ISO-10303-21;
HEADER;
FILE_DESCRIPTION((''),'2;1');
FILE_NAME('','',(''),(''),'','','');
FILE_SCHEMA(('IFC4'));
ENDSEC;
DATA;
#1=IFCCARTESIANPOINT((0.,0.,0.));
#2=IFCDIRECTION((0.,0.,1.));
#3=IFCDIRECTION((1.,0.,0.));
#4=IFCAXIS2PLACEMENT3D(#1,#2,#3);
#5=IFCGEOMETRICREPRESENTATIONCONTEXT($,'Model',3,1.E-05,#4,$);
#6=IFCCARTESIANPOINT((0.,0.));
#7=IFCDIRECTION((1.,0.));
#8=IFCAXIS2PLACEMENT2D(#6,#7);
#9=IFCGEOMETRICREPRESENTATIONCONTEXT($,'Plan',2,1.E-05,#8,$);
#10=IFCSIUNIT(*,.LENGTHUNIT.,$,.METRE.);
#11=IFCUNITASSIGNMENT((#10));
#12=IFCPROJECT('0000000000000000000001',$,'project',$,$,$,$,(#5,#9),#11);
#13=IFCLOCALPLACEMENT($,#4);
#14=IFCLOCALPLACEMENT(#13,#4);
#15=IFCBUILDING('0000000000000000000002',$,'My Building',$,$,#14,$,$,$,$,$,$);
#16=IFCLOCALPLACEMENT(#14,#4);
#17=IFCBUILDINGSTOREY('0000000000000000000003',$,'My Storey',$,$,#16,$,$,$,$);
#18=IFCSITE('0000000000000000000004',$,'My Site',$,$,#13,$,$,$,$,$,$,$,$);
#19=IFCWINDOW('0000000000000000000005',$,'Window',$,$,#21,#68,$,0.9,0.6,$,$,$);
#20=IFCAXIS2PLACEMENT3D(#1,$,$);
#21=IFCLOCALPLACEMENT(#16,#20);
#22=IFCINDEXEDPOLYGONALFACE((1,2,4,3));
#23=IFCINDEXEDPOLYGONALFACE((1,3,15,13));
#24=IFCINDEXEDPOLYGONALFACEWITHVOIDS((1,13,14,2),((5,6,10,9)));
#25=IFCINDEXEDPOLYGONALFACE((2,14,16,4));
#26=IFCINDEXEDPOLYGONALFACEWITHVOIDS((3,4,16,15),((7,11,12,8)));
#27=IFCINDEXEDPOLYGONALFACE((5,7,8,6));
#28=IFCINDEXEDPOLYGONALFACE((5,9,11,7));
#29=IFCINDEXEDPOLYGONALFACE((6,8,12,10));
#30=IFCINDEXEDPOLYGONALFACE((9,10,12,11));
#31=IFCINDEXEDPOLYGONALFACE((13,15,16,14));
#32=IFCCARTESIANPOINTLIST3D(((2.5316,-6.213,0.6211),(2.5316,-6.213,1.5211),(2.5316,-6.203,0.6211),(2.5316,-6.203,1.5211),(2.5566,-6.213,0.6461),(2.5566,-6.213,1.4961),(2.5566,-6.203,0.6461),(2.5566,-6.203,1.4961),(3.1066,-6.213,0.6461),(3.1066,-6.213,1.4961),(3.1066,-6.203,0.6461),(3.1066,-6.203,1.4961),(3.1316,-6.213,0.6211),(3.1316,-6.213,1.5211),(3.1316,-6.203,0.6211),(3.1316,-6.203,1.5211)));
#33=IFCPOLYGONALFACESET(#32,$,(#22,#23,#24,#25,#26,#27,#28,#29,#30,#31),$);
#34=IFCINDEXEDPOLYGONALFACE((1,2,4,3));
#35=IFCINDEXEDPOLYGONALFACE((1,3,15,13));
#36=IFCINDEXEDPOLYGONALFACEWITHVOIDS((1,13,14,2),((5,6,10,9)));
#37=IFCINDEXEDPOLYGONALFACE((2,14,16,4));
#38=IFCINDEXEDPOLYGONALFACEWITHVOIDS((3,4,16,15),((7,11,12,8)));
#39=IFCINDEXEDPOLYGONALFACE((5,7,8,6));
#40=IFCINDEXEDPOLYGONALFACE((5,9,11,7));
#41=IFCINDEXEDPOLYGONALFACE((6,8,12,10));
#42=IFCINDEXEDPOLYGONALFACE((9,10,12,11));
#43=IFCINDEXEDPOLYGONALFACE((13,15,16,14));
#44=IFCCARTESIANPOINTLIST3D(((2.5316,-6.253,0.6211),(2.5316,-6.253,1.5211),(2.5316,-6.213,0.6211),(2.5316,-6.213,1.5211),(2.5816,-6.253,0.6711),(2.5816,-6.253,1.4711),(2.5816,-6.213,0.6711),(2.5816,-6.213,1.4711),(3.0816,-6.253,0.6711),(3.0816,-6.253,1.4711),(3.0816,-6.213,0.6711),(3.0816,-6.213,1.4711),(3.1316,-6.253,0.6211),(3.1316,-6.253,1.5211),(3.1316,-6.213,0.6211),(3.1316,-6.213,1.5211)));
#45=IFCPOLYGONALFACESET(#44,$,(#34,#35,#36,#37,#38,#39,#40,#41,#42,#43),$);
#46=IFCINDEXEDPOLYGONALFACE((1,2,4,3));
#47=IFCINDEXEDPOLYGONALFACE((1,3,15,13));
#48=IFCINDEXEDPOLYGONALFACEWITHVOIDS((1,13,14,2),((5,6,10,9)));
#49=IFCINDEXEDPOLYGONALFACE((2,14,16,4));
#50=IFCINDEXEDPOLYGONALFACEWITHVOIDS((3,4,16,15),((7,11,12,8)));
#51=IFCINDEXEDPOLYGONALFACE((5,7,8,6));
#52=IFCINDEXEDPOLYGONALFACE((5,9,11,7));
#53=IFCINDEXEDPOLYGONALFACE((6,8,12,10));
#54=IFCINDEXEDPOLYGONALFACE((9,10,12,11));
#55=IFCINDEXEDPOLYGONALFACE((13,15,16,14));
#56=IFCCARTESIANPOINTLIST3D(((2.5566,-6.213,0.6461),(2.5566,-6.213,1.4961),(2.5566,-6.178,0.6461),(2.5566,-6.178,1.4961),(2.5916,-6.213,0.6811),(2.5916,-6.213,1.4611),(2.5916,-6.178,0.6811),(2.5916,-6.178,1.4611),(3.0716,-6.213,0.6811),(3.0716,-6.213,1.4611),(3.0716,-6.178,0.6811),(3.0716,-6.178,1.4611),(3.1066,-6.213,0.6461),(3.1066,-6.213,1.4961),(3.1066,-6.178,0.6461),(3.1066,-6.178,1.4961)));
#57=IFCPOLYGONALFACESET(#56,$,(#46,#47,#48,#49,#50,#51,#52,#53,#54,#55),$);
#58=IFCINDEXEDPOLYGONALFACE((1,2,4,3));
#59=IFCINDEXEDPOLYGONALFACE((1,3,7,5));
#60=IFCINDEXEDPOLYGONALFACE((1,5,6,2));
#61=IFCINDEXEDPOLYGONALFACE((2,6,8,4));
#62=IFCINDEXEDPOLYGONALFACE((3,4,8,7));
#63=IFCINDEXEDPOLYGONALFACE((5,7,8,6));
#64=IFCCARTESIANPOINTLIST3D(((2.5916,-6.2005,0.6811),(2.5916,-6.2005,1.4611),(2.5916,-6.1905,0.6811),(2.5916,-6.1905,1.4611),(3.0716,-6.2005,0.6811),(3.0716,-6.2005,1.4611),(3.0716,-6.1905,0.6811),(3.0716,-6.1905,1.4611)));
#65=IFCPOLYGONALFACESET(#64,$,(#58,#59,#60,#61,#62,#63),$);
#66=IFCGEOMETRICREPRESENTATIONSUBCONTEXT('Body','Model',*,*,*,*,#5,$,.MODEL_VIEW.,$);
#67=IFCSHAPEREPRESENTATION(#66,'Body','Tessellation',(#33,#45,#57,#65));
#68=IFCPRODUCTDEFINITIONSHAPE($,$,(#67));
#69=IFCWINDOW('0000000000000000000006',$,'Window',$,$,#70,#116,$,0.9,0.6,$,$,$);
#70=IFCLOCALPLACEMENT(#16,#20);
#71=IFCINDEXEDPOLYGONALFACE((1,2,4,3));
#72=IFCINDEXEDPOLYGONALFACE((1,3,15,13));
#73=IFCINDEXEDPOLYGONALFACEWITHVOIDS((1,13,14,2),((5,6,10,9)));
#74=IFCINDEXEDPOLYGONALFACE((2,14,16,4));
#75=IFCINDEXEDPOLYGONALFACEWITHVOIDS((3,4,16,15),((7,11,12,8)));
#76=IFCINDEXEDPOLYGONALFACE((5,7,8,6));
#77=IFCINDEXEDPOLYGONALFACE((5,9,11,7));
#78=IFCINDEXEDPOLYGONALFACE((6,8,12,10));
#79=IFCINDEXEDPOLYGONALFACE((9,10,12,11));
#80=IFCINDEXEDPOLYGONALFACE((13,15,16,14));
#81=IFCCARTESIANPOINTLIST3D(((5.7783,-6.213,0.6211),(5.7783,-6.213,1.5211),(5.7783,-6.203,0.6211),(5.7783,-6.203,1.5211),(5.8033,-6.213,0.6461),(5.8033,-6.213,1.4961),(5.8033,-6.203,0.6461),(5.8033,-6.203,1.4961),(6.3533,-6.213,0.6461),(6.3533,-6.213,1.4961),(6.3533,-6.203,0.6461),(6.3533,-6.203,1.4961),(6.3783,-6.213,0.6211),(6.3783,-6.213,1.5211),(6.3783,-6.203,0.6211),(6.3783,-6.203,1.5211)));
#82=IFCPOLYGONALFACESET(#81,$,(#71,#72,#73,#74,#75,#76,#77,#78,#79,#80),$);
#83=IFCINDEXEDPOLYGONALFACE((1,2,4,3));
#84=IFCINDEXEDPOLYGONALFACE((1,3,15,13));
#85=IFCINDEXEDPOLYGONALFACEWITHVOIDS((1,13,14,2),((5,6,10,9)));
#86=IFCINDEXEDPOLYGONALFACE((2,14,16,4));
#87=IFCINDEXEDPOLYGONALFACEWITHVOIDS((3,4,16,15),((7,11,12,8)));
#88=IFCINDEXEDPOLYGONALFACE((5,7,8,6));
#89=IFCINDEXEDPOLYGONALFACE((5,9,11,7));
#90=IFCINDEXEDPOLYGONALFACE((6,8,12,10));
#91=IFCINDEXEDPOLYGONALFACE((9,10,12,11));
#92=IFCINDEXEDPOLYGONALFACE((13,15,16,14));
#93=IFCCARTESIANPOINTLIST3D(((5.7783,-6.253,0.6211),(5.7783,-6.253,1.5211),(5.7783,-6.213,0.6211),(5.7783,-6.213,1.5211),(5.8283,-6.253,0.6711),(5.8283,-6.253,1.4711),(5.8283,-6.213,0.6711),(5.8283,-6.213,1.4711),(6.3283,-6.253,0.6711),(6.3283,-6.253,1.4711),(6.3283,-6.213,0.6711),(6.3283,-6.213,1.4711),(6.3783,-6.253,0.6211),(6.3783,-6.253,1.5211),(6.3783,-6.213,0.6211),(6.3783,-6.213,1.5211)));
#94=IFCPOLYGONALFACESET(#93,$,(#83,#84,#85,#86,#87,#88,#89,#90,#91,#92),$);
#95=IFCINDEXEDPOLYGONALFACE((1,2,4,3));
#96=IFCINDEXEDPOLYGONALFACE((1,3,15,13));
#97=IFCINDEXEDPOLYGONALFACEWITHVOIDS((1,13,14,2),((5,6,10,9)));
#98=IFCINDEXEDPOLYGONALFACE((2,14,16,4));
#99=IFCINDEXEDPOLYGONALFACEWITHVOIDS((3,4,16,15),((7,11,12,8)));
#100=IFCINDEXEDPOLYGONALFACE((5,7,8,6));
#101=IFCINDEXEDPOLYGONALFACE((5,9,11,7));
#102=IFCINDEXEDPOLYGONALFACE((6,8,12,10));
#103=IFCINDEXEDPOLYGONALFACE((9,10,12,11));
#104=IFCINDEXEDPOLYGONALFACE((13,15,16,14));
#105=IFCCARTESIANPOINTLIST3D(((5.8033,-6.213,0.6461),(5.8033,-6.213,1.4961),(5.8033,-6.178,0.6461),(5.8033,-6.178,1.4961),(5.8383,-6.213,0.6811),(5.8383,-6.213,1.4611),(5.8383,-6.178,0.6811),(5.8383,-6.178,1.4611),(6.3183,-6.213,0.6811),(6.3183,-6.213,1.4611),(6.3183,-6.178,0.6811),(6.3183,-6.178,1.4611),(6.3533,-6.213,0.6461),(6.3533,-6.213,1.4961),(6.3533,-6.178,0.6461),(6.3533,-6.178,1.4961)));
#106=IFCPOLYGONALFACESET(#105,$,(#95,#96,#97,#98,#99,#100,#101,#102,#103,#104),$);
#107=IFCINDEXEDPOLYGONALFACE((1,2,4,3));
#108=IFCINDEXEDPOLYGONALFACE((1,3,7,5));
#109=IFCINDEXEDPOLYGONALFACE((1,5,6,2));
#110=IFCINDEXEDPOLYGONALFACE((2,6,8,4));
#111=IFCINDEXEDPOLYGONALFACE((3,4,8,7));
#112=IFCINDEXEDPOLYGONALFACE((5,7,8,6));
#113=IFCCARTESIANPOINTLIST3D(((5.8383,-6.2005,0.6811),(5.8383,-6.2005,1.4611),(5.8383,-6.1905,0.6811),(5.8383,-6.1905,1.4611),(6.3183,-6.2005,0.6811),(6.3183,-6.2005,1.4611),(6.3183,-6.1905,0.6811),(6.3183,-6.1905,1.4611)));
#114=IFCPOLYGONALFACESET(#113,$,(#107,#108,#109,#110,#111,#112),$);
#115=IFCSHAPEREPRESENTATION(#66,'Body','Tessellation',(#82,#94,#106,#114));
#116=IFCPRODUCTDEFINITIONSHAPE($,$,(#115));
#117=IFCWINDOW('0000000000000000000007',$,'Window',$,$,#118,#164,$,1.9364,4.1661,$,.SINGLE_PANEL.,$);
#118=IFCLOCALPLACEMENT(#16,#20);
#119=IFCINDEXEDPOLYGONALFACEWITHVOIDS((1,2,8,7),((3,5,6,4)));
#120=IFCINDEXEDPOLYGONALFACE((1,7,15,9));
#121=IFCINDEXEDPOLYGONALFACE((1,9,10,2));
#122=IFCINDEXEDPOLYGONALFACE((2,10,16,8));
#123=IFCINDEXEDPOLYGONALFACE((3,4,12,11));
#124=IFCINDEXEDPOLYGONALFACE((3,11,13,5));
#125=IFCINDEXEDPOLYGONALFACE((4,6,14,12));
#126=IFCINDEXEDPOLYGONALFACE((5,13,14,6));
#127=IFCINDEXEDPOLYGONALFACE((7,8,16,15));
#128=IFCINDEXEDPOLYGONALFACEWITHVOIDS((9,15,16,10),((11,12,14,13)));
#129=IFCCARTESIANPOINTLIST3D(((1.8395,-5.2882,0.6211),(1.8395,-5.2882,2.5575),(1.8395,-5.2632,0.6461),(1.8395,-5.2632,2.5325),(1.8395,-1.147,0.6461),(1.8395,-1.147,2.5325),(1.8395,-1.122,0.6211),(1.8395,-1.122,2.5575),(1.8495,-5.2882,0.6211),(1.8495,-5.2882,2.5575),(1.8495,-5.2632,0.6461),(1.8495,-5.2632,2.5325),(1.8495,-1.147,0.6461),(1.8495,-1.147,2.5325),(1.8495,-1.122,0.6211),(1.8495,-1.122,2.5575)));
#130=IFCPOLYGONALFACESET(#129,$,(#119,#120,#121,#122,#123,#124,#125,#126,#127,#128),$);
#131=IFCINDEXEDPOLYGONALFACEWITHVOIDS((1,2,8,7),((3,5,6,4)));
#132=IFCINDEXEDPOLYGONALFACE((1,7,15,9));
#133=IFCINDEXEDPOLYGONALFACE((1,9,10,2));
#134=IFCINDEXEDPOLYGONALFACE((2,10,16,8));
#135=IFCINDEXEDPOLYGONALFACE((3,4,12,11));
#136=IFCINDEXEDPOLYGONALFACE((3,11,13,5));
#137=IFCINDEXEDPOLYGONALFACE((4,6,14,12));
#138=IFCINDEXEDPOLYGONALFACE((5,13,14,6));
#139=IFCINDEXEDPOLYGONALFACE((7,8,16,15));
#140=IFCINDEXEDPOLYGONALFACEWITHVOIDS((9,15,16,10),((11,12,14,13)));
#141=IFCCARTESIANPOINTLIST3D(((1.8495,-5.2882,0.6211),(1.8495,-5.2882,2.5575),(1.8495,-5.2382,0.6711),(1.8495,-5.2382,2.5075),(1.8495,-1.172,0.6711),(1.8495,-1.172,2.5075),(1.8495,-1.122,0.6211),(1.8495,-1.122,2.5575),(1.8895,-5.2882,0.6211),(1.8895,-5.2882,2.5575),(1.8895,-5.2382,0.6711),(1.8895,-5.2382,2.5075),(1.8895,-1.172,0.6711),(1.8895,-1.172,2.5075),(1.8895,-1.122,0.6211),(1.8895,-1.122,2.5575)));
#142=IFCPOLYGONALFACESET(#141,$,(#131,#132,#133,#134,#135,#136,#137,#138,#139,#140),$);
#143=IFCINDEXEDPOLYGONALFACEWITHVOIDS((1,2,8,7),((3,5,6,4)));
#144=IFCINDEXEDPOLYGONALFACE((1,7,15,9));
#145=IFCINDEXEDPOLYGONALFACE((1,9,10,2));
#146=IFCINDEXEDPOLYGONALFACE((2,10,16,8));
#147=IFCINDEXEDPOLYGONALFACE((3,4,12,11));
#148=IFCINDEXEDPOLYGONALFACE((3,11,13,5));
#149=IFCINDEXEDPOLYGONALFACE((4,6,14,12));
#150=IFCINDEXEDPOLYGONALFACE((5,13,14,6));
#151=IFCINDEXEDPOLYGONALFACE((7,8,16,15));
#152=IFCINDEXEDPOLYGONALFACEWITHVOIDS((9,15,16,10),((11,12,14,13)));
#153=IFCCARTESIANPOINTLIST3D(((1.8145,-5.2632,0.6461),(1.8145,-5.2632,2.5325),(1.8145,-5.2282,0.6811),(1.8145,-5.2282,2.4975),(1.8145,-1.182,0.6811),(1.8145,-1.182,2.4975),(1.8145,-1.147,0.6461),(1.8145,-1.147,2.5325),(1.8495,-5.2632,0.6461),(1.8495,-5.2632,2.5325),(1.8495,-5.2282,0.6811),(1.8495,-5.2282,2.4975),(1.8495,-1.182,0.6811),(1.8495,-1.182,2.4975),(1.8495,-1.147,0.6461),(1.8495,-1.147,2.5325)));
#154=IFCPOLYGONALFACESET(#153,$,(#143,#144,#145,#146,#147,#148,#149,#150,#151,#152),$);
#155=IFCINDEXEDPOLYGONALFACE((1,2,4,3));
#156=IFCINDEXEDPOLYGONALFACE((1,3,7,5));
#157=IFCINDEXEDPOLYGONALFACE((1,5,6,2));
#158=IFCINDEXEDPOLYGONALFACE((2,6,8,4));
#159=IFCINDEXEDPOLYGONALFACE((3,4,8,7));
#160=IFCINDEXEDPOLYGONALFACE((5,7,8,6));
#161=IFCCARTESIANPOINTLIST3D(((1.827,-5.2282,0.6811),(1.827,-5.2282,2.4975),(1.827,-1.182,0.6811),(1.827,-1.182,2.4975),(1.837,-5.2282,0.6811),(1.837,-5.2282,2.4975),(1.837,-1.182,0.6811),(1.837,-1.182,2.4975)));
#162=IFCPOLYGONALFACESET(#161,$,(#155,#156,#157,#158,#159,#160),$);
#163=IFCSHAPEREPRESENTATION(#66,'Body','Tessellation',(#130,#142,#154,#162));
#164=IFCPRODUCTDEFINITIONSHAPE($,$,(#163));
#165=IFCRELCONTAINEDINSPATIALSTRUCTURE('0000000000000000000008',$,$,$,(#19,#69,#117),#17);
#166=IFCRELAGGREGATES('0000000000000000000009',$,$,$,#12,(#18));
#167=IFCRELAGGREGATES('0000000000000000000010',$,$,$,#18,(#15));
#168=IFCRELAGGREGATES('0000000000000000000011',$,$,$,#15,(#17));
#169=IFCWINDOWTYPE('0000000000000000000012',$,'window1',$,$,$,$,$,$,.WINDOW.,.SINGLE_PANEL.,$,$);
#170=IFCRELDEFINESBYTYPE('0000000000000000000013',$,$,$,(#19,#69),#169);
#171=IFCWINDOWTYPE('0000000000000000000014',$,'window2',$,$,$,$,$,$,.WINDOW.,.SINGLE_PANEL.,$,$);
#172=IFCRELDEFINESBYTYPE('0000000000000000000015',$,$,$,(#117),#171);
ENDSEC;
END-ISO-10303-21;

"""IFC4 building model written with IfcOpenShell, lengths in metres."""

from ifc_helpers import new_model, entity, si_unit, frame, origin_with_axes, origin_2d_with_axis, place, context, subcontext, project, spatial, line, indexed_curve, outline, extrude, shape, source, transform, mapped, type_object, type_shapes, element, save


model = new_model("IFC4")

# Units and contexts
model_context = context("Model", 3, precision=1e-05, world=origin_with_axes())
plan_context = context("Plan", 2, precision=1e-05, world=origin_2d_with_axis())
body_context_1 = subcontext(model_context, "Body", "Model", "MODEL_VIEW")
body_context_2 = subcontext(plan_context, "Body", "Plan", "PLAN_VIEW")
ifc_project = project(units=[si_unit("LENGTHUNIT", "METRE")], contexts=[model_context, plan_context])

# Site, building, storey
site_placement = place(None, origin_with_axes())
site = spatial("IfcSite", under=ifc_project, at=site_placement, Name="My Site")
building_placement = place(site_placement, origin_with_axes())
building = spatial("IfcBuilding", under=site, at=building_placement, Name="My Building")
storey_placement = place(building_placement, origin_with_axes())
storey = spatial("IfcBuildingStorey", under=building, at=storey_placement, Name="My Storey")

# Windows
window_type_1 = type_object("IfcWindowType", Name="window1", PartitioningType="SINGLE_PANEL", PredefinedType="WINDOW")
shared_shape_1 = source(origin_with_axes(), body_context_1, "Body", "SweptSolid", [
    extrude(outline(indexed_curve([(0.0, 0.0), (0.6, 0.0), (0.6, 0.9), (0.0, 0.9)], segments=[line(1, 2, 3, 4, 1)]), holes=[indexed_curve([(0.025, 0.025), (0.575, 0.025), (0.575, 0.875), (0.025, 0.875)], segments=[line(1, 2, 3, 4, 1)])]), frame((0.0, 0.09, 0.0), z_axis=(0.0, -1.0, 0.0), x_axis=(1.0, 0.0, 0.0)), (0.0, 0.0, -1.0), 0.01),
    extrude(outline(indexed_curve([(0.0, 0.0), (0.6, 0.0), (0.6, 0.9), (0.0, 0.9)], segments=[line(1, 2, 3, 4, 1)]), holes=[indexed_curve([(0.05, 0.05), (0.55, 0.05), (0.55, 0.85), (0.05, 0.85)], segments=[line(1, 2, 3, 4, 1)])]), frame((0.0, 0.05, 0.0), z_axis=(0.0, -1.0, 0.0), x_axis=(1.0, 0.0, 0.0)), (0.0, 0.0, -1.0), 0.04),
    extrude(outline(indexed_curve([(0.0, 0.0), (0.55, 0.0), (0.55, 0.85), (0.0, 0.85)], segments=[line(1, 2, 3, 4, 1)]), holes=[indexed_curve([(0.035, 0.035), (0.515, 0.035), (0.515, 0.815), (0.035, 0.815)], segments=[line(1, 2, 3, 4, 1)])]), frame((0.025, 0.09, 0.025), z_axis=(0.0, -1.0, 0.0), x_axis=(1.0, 0.0, 0.0)), (0.0, 0.0, -1.0), 0.035),
    extrude(outline(indexed_curve([(0.035, 0.035), (0.515, 0.035), (0.515, 0.815), (0.035, 0.815)], segments=[line(1, 2, 3, 4, 1)])), frame((0.025, 0.1025, 0.025), z_axis=(0.0, -1.0, 0.0), x_axis=(1.0, 0.0, 0.0)), (0.0, 0.0, -1.0), 0.01),
])
shared_shape_2 = source(origin_with_axes(), body_context_2, "Body", "Curve2D", [
    entity("IfcIndexedPolyCurve", entity("IfcCartesianPointList2D", [[0.05, 0.05], [0.55, 0.05]])),
    entity("IfcIndexedPolyCurve", entity("IfcCartesianPointList2D", [[0.0, 0.1], [0.025, 0.1], [0.025, 0.09], [0.05, 0.09], [0.05, 0.05], [0.0, 0.05]]), [entity("IfcLineIndex", [1, 2, 3, 4, 5, 6, 1])]),
    entity("IfcIndexedPolyCurve", entity("IfcCartesianPointList2D", [[0.6, 0.1], [0.575, 0.1], [0.575, 0.09], [0.55, 0.09], [0.55, 0.05], [0.6, 0.05]]), [entity("IfcLineIndex", [1, 2, 3, 4, 5, 6, 1])]),
    entity("IfcIndexedPolyCurve", entity("IfcCartesianPointList2D", [[0.025, 0.09], [0.06, 0.09], [0.06, 0.125], [0.025, 0.125]]), [entity("IfcLineIndex", [1, 2, 3, 4, 1])]),
    entity("IfcIndexedPolyCurve", entity("IfcCartesianPointList2D", [[0.575, 0.09], [0.54, 0.09], [0.54, 0.125], [0.575, 0.125]]), [entity("IfcLineIndex", [1, 2, 3, 4, 1])]),
    entity("IfcIndexedPolyCurve", entity("IfcCartesianPointList2D", [[0.06, 0.09], [0.54, 0.09]])),
    entity("IfcIndexedPolyCurve", entity("IfcCartesianPointList2D", [[0.06, 0.125], [0.54, 0.125]])),
    entity("IfcIndexedPolyCurve", entity("IfcCartesianPointList2D", [[0.06, 0.1075], [0.54, 0.1075]])),
])
type_shapes(window_type_1, [shared_shape_1, shared_shape_2])
for number, where, z_axis, x_axis, name in (
    (1, (2.5316, -6.303, 0.6211), (0.0, 0.0, 1.0), (1.0, 0.0, 0.0), "Window"),
    (2, (5.7783, -6.303, 0.6211), (0.0, 0.0, 1.0), (1.0, 0.0, 0.0), "Window"),
):
    element("IfcWindow", number, at=place(storey_placement, frame(where, z_axis=z_axis, x_axis=x_axis)), inside=storey, type_object=window_type_1, Name=name, OverallHeight=0.9, OverallWidth=0.6, shapes=[
        shape(body_context_1, "Body", "MappedRepresentation", [mapped(shared_shape_1, transform((0.0, 0.0, 0.0), x_axis=(1.0, 0.0, 0.0), y_axis=(0.0, 1.0, 0.0), z_axis=(0.0, 0.0, 1.0), scale=1.0))]),
        shape(body_context_2, "Body", "MappedRepresentation", [mapped(shared_shape_2, transform((0.0, 0.0, 0.0), x_axis=(1.0, 0.0, 0.0), y_axis=(0.0, 1.0, 0.0), z_axis=(0.0, 0.0, 1.0), scale=1.0))]),
    ])
window_type_2 = type_object("IfcWindowType", Name="window2", PartitioningType="SINGLE_PANEL", PredefinedType="WINDOW")
shared_shape_3 = source(origin_with_axes(), body_context_1, "Body", "SweptSolid", [
    extrude(outline(indexed_curve([(0.0, 0.0), (4.1661, 0.0), (4.1661, 1.9364), (0.0, 1.9364)], segments=[line(1, 2, 3, 4, 1)]), holes=[indexed_curve([(0.025, 0.025), (4.1411, 0.025), (4.1411, 1.9114), (0.025, 1.9114)], segments=[line(1, 2, 3, 4, 1)])]), frame((0.0, 0.09, 0.0), z_axis=(0.0, -1.0, 0.0), x_axis=(1.0, 0.0, 0.0)), (0.0, 0.0, -1.0), 0.01),
    extrude(outline(indexed_curve([(0.0, 0.0), (4.1661, 0.0), (4.1661, 1.9364), (0.0, 1.9364)], segments=[line(1, 2, 3, 4, 1)]), holes=[indexed_curve([(0.05, 0.05), (4.1161, 0.05), (4.1161, 1.8864), (0.05, 1.8864)], segments=[line(1, 2, 3, 4, 1)])]), frame((0.0, 0.05, 0.0), z_axis=(0.0, -1.0, 0.0), x_axis=(1.0, 0.0, 0.0)), (0.0, 0.0, -1.0), 0.04),
    extrude(outline(indexed_curve([(0.0, 0.0), (4.1161, 0.0), (4.1161, 1.8864), (0.0, 1.8864)], segments=[line(1, 2, 3, 4, 1)]), holes=[indexed_curve([(0.035, 0.035), (4.0811, 0.035), (4.0811, 1.8514), (0.035, 1.8514)], segments=[line(1, 2, 3, 4, 1)])]), frame((0.025, 0.09, 0.025), z_axis=(0.0, -1.0, 0.0), x_axis=(1.0, 0.0, 0.0)), (0.0, 0.0, -1.0), 0.035),
    extrude(outline(indexed_curve([(0.035, 0.035), (4.0811, 0.035), (4.0811, 1.8514), (0.035, 1.8514)], segments=[line(1, 2, 3, 4, 1)])), frame((0.025, 0.1025, 0.025), z_axis=(0.0, -1.0, 0.0), x_axis=(1.0, 0.0, 0.0)), (0.0, 0.0, -1.0), 0.01),
])
shared_shape_4 = source(origin_with_axes(), body_context_2, "Body", "Curve2D", [
    entity("IfcIndexedPolyCurve", entity("IfcCartesianPointList2D", [[0.05, 0.05], [4.1161, 0.05]])),
    entity("IfcIndexedPolyCurve", entity("IfcCartesianPointList2D", [[0.0, 0.1], [0.025, 0.1], [0.025, 0.09], [0.05, 0.09], [0.05, 0.05], [0.0, 0.05]]), [entity("IfcLineIndex", [1, 2, 3, 4, 5, 6, 1])]),
    entity("IfcIndexedPolyCurve", entity("IfcCartesianPointList2D", [[4.1661, 0.1], [4.1411, 0.1], [4.1411, 0.09], [4.1161, 0.09], [4.1161, 0.05], [4.1661, 0.05]]), [entity("IfcLineIndex", [1, 2, 3, 4, 5, 6, 1])]),
    entity("IfcIndexedPolyCurve", entity("IfcCartesianPointList2D", [[0.025, 0.09], [0.06, 0.09], [0.06, 0.125], [0.025, 0.125]]), [entity("IfcLineIndex", [1, 2, 3, 4, 1])]),
    entity("IfcIndexedPolyCurve", entity("IfcCartesianPointList2D", [[4.1411, 0.09], [4.1061, 0.09], [4.1061, 0.125], [4.1411, 0.125]]), [entity("IfcLineIndex", [1, 2, 3, 4, 1])]),
    entity("IfcIndexedPolyCurve", entity("IfcCartesianPointList2D", [[0.06, 0.09], [4.1061, 0.09]])),
    entity("IfcIndexedPolyCurve", entity("IfcCartesianPointList2D", [[0.06, 0.125], [4.1061, 0.125]])),
    entity("IfcIndexedPolyCurve", entity("IfcCartesianPointList2D", [[0.06, 0.1075], [4.1061, 0.1075]])),
])
type_shapes(window_type_2, [shared_shape_3, shared_shape_4])
window_placement = place(storey_placement, frame((1.9395, -5.2882, 0.6211), z_axis=(0.0, 0.0, 1.0), x_axis=(0.0, 1.0, 0.0)))
element("IfcWindow", 3, at=window_placement, inside=storey, type_object=window_type_2, Name="Window", OverallHeight=1.9364, OverallWidth=4.1661, PartitioningType="SINGLE_PANEL", shapes=[
    shape(body_context_1, "Body", "MappedRepresentation", [mapped(shared_shape_3, transform((0.0, 0.0, 0.0), x_axis=(1.0, 0.0, 0.0), y_axis=(0.0, 1.0, 0.0), z_axis=(0.0, 0.0, 1.0), scale=1.0))]),
    shape(body_context_2, "Body", "MappedRepresentation", [mapped(shared_shape_4, transform((0.0, 0.0, 0.0), x_axis=(1.0, 0.0, 0.0), y_axis=(0.0, 1.0, 0.0), z_axis=(0.0, 0.0, 1.0), scale=1.0))]),
])

save(model, "model.ifc")
